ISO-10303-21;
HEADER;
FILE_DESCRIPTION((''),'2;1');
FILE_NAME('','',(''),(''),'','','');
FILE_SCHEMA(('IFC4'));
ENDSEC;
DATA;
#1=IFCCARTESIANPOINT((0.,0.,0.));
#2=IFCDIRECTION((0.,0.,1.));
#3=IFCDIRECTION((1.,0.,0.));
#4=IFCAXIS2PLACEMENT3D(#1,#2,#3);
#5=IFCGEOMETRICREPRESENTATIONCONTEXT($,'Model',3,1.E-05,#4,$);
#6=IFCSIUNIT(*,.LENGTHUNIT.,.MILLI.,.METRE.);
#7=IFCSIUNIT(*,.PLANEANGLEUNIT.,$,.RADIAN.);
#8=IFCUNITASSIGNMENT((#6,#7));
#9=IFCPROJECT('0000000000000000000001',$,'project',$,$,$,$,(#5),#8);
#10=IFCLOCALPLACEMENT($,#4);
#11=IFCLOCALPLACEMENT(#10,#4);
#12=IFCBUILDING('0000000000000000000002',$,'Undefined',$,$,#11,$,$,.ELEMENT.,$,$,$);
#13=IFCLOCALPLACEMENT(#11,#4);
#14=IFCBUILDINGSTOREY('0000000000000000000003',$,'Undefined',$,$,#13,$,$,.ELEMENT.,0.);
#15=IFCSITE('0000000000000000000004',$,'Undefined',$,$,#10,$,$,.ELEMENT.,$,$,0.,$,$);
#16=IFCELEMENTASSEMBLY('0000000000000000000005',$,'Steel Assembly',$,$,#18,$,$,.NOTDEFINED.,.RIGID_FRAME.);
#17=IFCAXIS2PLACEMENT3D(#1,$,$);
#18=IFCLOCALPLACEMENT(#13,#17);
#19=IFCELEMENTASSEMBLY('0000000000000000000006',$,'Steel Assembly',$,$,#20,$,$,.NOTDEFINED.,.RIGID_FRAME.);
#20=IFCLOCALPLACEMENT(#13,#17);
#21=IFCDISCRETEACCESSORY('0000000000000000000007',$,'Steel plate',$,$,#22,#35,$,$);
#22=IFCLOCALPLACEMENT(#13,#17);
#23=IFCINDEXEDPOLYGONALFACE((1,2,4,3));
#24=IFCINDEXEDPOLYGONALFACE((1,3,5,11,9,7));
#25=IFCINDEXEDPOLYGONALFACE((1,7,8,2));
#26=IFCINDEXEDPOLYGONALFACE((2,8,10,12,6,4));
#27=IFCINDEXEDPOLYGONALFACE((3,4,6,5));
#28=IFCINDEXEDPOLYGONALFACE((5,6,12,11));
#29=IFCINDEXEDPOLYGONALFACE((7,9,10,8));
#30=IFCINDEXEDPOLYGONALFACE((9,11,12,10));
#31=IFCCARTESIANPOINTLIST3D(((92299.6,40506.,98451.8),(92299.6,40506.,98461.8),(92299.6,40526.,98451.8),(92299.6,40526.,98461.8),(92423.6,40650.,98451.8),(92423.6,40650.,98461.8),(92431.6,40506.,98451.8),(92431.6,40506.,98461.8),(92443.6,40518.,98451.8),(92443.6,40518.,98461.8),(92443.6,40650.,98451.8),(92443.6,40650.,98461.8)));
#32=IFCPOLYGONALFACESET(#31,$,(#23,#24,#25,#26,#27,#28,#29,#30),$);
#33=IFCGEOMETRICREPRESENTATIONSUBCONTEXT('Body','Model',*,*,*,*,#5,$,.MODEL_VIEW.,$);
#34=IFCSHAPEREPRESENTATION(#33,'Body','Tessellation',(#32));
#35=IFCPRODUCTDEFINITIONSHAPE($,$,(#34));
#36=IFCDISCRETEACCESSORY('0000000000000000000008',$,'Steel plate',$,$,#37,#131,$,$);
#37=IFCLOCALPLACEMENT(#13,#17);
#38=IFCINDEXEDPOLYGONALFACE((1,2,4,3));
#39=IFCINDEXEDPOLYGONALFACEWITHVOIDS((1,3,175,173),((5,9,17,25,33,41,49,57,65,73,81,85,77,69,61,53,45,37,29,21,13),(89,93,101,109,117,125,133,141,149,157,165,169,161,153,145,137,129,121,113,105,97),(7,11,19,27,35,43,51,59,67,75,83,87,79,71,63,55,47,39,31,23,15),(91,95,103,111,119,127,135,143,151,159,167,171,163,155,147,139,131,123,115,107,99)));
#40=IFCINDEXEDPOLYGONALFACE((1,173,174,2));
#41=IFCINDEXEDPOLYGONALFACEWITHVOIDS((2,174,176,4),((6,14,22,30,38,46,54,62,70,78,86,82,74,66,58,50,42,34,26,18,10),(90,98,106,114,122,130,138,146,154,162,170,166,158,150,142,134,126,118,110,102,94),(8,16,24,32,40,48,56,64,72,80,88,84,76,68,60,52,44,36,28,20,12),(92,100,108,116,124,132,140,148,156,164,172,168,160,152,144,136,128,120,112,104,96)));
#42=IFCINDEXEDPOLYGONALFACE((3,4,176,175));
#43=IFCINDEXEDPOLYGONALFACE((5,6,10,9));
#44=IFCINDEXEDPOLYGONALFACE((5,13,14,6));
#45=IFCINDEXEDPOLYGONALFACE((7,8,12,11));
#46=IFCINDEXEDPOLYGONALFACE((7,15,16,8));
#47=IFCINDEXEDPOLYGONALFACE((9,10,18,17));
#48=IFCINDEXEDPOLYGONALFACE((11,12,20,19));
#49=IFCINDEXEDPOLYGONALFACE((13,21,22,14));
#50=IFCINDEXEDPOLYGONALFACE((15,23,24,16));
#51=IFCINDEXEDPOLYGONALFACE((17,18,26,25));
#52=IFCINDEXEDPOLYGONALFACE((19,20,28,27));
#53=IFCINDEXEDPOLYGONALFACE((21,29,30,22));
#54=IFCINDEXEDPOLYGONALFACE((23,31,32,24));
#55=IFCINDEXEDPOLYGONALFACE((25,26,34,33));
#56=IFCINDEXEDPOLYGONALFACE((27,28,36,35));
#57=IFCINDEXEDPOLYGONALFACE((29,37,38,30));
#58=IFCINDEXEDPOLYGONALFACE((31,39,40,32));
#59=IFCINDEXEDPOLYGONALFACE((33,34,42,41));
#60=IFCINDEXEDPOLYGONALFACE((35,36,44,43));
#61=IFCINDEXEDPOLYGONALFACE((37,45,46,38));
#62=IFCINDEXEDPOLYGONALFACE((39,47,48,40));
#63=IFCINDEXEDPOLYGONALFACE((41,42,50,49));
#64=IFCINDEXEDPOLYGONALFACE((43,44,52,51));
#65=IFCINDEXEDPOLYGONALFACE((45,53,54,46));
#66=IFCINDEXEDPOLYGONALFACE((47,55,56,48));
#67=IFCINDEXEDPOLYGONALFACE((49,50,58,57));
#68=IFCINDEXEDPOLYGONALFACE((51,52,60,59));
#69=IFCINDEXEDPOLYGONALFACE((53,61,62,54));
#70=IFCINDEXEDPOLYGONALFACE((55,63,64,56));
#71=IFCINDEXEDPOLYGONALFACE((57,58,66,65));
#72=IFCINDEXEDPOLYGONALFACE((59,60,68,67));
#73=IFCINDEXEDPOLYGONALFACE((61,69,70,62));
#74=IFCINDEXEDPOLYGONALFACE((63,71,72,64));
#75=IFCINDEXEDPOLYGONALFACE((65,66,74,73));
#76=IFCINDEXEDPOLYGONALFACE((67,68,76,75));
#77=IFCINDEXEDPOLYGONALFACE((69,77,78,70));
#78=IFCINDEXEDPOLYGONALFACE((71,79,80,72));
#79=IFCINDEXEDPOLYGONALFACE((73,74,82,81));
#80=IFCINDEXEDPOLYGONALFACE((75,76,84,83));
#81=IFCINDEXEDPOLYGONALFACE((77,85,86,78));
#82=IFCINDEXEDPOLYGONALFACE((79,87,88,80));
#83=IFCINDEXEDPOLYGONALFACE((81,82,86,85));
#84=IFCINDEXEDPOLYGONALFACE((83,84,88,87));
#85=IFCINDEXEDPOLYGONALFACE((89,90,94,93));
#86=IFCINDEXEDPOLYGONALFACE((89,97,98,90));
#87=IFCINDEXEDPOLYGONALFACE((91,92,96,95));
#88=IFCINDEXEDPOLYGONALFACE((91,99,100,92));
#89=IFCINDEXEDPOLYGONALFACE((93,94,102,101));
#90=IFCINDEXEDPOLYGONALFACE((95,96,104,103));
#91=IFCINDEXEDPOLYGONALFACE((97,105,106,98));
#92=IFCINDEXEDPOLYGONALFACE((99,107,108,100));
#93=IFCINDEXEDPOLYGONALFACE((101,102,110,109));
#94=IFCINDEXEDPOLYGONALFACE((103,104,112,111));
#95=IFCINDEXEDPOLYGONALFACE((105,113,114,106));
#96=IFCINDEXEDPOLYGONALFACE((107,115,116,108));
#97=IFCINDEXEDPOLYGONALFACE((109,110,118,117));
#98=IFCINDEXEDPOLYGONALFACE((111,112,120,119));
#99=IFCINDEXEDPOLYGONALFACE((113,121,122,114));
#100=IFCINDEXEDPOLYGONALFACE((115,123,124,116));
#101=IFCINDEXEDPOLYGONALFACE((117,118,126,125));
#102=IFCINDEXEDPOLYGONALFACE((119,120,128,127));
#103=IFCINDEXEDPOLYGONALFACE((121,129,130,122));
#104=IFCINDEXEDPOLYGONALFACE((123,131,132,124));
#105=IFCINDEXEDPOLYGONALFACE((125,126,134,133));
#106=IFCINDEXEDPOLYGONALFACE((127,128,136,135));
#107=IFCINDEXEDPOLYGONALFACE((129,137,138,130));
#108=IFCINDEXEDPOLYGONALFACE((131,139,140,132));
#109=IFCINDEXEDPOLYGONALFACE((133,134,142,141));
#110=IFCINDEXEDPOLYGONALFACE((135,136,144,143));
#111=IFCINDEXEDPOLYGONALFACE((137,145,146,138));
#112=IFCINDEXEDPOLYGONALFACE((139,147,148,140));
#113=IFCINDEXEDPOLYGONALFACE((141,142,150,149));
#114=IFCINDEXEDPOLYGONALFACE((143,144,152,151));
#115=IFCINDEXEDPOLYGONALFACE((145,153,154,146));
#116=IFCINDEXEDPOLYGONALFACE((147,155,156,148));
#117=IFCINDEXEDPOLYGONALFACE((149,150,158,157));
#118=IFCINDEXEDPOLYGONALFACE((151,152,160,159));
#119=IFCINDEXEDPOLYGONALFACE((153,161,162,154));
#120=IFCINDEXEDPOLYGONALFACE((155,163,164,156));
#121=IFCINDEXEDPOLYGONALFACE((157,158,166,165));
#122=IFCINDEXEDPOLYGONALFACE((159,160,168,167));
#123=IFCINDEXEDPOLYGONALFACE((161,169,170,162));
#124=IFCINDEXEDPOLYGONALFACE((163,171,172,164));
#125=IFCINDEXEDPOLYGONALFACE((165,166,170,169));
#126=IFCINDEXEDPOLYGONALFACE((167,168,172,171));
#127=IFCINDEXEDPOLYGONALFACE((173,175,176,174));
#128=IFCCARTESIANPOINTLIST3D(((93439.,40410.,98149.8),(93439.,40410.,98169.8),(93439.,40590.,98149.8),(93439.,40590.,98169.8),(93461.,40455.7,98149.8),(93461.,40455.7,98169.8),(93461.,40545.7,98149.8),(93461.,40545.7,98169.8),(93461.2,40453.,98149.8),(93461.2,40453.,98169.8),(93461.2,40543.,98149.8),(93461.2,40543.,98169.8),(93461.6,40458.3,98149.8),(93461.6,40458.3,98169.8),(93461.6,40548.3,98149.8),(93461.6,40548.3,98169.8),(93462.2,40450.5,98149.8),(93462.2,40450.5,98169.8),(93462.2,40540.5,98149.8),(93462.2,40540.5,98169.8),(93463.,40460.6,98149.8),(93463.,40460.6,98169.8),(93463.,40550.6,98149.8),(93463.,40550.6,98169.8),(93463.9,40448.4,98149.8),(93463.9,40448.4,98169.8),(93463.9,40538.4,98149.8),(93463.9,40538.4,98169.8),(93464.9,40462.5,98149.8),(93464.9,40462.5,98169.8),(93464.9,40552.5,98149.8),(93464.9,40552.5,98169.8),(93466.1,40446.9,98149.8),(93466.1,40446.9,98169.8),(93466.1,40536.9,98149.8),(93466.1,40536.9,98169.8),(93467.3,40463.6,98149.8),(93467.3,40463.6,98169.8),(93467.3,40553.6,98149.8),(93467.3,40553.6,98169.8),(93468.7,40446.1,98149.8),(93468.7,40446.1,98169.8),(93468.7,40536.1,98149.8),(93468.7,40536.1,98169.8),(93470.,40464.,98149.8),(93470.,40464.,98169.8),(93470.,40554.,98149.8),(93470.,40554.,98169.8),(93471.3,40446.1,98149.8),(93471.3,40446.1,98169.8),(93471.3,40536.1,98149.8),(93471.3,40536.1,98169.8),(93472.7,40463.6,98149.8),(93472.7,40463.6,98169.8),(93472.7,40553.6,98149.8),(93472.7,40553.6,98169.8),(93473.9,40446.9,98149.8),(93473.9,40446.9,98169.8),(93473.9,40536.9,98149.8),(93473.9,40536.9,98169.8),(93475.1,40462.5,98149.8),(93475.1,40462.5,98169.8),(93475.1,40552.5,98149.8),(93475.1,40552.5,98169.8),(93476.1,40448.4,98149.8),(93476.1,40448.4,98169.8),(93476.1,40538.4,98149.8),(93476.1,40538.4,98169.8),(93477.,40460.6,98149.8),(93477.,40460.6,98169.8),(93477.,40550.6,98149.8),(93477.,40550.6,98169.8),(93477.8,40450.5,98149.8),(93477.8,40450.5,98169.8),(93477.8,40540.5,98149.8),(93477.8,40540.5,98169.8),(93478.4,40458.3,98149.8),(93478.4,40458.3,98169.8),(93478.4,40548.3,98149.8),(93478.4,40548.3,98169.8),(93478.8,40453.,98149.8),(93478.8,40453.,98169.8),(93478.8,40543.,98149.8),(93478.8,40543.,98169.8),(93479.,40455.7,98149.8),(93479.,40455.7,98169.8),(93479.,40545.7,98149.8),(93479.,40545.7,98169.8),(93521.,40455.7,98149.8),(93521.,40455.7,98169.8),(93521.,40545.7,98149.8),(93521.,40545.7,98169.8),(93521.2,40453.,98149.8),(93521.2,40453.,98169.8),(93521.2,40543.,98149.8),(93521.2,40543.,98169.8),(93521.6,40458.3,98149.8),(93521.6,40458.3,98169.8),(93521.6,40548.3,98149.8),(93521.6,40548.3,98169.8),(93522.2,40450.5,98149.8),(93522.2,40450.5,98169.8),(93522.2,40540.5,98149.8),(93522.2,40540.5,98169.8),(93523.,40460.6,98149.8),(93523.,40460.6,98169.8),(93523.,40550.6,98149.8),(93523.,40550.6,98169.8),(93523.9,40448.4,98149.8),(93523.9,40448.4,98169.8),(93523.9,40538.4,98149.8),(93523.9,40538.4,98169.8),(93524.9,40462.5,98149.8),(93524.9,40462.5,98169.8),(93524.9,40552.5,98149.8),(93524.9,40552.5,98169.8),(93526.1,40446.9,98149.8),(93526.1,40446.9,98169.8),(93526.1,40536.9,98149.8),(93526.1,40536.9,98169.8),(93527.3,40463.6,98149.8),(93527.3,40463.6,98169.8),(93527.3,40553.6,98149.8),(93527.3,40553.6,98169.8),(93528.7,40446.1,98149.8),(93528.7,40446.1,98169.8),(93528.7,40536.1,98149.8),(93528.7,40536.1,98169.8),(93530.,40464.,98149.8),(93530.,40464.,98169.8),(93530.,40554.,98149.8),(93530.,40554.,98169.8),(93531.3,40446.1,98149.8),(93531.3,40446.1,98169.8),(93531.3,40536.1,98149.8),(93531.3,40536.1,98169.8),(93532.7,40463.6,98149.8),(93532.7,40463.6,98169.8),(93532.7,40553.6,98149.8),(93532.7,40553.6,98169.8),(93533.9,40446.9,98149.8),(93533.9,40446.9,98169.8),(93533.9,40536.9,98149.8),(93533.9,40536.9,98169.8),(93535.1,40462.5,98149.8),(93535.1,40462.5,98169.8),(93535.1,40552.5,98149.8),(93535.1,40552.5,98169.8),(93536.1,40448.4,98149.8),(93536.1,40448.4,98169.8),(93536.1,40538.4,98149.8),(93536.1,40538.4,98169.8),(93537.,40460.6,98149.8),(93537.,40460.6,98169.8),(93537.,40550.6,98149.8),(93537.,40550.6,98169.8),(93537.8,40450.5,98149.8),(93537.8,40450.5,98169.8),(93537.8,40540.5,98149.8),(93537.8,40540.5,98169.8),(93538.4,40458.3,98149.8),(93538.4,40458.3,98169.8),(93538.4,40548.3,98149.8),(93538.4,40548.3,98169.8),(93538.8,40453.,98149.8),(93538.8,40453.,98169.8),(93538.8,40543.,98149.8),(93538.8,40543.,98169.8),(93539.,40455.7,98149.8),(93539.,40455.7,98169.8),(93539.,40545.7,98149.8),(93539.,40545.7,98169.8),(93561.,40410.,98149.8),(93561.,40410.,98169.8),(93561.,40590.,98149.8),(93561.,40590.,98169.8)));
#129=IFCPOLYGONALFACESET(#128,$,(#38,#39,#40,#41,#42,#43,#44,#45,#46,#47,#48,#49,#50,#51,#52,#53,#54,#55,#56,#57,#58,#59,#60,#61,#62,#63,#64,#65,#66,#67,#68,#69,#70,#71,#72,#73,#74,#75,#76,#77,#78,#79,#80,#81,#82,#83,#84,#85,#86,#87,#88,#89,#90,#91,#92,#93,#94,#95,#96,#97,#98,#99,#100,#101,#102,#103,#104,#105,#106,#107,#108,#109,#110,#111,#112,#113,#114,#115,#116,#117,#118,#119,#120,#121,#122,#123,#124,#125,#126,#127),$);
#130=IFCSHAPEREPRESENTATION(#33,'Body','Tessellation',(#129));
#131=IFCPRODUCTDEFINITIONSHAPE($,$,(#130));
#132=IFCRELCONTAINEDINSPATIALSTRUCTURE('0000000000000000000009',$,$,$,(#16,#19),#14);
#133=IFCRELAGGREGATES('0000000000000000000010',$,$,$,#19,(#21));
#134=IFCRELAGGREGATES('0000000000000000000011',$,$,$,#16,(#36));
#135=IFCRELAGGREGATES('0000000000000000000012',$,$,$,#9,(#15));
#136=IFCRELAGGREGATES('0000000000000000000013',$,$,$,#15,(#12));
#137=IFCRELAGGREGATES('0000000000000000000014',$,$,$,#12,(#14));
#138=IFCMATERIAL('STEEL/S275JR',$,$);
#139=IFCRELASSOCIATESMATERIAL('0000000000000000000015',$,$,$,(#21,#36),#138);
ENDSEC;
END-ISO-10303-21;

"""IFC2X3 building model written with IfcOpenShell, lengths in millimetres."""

from ifc_helpers import new_model, si_unit, frame, origin_with_axes, origin_2d_with_axis, place, context, subcontext, project, spatial, polyline, circle, outline, extrude, source, transform, mapped, material, element, aggregate, save


model = new_model("IFC2X3")

# Units and contexts
model_context = context("Model", 3, precision=1e-05, world=origin_with_axes())
body_context = subcontext(model_context, "Body", "Model", "MODEL_VIEW")
ifc_project = project(units=[si_unit("LENGTHUNIT", "METRE", prefix="MILLI"), si_unit("PLANEANGLEUNIT", "RADIAN")], contexts=[model_context])

# Site, building, storey
site_placement = place(None, origin_with_axes())
site = spatial("IfcSite", under=ifc_project, at=site_placement, Name="Undefined", CompositionType="ELEMENT", RefElevation=0.0)
building_placement = place(site_placement, origin_with_axes())
building = spatial("IfcBuilding", under=site, at=building_placement, Name="Undefined", CompositionType="ELEMENT")
storey_placement = place(building_placement, origin_with_axes())
storey = spatial("IfcBuildingStorey", under=building, at=storey_placement, Name="Undefined", CompositionType="ELEMENT", Elevation=0.0)

# Shared definitions
ifc_material_1 = material(Name="STEEL/S275JR")

# Element assembly
assembly_1_placement = place(storey_placement, origin_with_axes())
assembly_1 = element("IfcElementAssembly", 1, at=assembly_1_placement, inside=storey, Name="Steel Assembly", AssemblyPlace="NOTDEFINED", PredefinedType="RIGID_FRAME")

# Element assembly
assembly_2_placement = place(storey_placement, origin_with_axes())
assembly_2 = element("IfcElementAssembly", 2, at=assembly_2_placement, inside=storey, Name="Steel Assembly", AssemblyPlace="NOTDEFINED", PredefinedType="RIGID_FRAME")

# Discrete accessory
discrete_accessory_1_placement = place(assembly_2_placement, frame((92443.6, 40506.0, 98456.8), z_axis=(0.0, 0.0, 1.0), x_axis=(0.000001, 1.0, 0.0)))
discrete_accessory_1 = element("IfcDiscreteAccessory", 3, at=discrete_accessory_1_placement, material=ifc_material_1, Name="Steel plate", context=body_context, shape_type="SweptSolid", body=[
    extrude(outline(polyline([(0.0, 12.0), (12.0, 0.0), (144.0, 0.0), (144.0, 20.0), (20.0, 144.0), (0.0, 144.0), (0.0, 12.0)])), frame((0.0, 0.0, -5.0), z_axis=(0.0, 0.0, 1.0), x_axis=(1.0, 0.0, 0.0)), (0.0, 0.0, 1.0), 10.0),
])

# Discrete accessory, opening
aggregate(assembly_2, [discrete_accessory_1])
discrete_accessory_2_placement = place(assembly_1_placement, frame((93439.0, 40590.0, 98159.8), z_axis=(0.0, 0.0, 1.0), x_axis=(0.0, -1.0, 0.0)))
discrete_accessory_2 = element("IfcDiscreteAccessory", 4, at=discrete_accessory_2_placement, material=ifc_material_1, Name="Steel plate", context=body_context, shape_type="SweptSolid", body=[
    extrude(outline(polyline([(0.0, 0.0), (180.0, 0.0), (180.0, 122.0), (0.0, 122.0), (0.0, 0.0)])), frame((0.0, 0.0, -10.0), z_axis=(0.0, 0.0, 1.0), x_axis=(1.0, 0.0, 0.0)), (0.0, 0.0, 1.0), 20.0),
])
shared_shape_1 = source(origin_with_axes(), body_context, "Body", "SweptSolid", [
    extrude(circle(Radius=9.0, at=origin_2d_with_axis()), frame((0.0, -0.1, 0.0), z_axis=(0.0, 1.0, 0.0), x_axis=(1.0, 0.0, 0.0)), (0.0, 0.0, 1.0), 20.2),
])
opening_1_placement = place(assembly_1_placement, frame((93500.0, 40455.0, 98169.8), z_axis=(-1.0, 0.0, 0.0), x_axis=(0.0, 1.0, 0.0)))
element("IfcOpeningElement", 5, at=opening_1_placement, cuts=discrete_accessory_2, ObjectType="Opening", context=body_context, shape_type="MappedRepresentation", body=[
    mapped(shared_shape_1, transform((0.0, 0.0, -30.0))),
    mapped(shared_shape_1, transform((90.0, 0.0, -30.0))),
    mapped(shared_shape_1, transform((0.0, 0.0, 30.0))),
    mapped(shared_shape_1, transform((90.0, 0.0, 30.0))),
])
aggregate(assembly_1, [discrete_accessory_2])

save(model, "model.ifc")
